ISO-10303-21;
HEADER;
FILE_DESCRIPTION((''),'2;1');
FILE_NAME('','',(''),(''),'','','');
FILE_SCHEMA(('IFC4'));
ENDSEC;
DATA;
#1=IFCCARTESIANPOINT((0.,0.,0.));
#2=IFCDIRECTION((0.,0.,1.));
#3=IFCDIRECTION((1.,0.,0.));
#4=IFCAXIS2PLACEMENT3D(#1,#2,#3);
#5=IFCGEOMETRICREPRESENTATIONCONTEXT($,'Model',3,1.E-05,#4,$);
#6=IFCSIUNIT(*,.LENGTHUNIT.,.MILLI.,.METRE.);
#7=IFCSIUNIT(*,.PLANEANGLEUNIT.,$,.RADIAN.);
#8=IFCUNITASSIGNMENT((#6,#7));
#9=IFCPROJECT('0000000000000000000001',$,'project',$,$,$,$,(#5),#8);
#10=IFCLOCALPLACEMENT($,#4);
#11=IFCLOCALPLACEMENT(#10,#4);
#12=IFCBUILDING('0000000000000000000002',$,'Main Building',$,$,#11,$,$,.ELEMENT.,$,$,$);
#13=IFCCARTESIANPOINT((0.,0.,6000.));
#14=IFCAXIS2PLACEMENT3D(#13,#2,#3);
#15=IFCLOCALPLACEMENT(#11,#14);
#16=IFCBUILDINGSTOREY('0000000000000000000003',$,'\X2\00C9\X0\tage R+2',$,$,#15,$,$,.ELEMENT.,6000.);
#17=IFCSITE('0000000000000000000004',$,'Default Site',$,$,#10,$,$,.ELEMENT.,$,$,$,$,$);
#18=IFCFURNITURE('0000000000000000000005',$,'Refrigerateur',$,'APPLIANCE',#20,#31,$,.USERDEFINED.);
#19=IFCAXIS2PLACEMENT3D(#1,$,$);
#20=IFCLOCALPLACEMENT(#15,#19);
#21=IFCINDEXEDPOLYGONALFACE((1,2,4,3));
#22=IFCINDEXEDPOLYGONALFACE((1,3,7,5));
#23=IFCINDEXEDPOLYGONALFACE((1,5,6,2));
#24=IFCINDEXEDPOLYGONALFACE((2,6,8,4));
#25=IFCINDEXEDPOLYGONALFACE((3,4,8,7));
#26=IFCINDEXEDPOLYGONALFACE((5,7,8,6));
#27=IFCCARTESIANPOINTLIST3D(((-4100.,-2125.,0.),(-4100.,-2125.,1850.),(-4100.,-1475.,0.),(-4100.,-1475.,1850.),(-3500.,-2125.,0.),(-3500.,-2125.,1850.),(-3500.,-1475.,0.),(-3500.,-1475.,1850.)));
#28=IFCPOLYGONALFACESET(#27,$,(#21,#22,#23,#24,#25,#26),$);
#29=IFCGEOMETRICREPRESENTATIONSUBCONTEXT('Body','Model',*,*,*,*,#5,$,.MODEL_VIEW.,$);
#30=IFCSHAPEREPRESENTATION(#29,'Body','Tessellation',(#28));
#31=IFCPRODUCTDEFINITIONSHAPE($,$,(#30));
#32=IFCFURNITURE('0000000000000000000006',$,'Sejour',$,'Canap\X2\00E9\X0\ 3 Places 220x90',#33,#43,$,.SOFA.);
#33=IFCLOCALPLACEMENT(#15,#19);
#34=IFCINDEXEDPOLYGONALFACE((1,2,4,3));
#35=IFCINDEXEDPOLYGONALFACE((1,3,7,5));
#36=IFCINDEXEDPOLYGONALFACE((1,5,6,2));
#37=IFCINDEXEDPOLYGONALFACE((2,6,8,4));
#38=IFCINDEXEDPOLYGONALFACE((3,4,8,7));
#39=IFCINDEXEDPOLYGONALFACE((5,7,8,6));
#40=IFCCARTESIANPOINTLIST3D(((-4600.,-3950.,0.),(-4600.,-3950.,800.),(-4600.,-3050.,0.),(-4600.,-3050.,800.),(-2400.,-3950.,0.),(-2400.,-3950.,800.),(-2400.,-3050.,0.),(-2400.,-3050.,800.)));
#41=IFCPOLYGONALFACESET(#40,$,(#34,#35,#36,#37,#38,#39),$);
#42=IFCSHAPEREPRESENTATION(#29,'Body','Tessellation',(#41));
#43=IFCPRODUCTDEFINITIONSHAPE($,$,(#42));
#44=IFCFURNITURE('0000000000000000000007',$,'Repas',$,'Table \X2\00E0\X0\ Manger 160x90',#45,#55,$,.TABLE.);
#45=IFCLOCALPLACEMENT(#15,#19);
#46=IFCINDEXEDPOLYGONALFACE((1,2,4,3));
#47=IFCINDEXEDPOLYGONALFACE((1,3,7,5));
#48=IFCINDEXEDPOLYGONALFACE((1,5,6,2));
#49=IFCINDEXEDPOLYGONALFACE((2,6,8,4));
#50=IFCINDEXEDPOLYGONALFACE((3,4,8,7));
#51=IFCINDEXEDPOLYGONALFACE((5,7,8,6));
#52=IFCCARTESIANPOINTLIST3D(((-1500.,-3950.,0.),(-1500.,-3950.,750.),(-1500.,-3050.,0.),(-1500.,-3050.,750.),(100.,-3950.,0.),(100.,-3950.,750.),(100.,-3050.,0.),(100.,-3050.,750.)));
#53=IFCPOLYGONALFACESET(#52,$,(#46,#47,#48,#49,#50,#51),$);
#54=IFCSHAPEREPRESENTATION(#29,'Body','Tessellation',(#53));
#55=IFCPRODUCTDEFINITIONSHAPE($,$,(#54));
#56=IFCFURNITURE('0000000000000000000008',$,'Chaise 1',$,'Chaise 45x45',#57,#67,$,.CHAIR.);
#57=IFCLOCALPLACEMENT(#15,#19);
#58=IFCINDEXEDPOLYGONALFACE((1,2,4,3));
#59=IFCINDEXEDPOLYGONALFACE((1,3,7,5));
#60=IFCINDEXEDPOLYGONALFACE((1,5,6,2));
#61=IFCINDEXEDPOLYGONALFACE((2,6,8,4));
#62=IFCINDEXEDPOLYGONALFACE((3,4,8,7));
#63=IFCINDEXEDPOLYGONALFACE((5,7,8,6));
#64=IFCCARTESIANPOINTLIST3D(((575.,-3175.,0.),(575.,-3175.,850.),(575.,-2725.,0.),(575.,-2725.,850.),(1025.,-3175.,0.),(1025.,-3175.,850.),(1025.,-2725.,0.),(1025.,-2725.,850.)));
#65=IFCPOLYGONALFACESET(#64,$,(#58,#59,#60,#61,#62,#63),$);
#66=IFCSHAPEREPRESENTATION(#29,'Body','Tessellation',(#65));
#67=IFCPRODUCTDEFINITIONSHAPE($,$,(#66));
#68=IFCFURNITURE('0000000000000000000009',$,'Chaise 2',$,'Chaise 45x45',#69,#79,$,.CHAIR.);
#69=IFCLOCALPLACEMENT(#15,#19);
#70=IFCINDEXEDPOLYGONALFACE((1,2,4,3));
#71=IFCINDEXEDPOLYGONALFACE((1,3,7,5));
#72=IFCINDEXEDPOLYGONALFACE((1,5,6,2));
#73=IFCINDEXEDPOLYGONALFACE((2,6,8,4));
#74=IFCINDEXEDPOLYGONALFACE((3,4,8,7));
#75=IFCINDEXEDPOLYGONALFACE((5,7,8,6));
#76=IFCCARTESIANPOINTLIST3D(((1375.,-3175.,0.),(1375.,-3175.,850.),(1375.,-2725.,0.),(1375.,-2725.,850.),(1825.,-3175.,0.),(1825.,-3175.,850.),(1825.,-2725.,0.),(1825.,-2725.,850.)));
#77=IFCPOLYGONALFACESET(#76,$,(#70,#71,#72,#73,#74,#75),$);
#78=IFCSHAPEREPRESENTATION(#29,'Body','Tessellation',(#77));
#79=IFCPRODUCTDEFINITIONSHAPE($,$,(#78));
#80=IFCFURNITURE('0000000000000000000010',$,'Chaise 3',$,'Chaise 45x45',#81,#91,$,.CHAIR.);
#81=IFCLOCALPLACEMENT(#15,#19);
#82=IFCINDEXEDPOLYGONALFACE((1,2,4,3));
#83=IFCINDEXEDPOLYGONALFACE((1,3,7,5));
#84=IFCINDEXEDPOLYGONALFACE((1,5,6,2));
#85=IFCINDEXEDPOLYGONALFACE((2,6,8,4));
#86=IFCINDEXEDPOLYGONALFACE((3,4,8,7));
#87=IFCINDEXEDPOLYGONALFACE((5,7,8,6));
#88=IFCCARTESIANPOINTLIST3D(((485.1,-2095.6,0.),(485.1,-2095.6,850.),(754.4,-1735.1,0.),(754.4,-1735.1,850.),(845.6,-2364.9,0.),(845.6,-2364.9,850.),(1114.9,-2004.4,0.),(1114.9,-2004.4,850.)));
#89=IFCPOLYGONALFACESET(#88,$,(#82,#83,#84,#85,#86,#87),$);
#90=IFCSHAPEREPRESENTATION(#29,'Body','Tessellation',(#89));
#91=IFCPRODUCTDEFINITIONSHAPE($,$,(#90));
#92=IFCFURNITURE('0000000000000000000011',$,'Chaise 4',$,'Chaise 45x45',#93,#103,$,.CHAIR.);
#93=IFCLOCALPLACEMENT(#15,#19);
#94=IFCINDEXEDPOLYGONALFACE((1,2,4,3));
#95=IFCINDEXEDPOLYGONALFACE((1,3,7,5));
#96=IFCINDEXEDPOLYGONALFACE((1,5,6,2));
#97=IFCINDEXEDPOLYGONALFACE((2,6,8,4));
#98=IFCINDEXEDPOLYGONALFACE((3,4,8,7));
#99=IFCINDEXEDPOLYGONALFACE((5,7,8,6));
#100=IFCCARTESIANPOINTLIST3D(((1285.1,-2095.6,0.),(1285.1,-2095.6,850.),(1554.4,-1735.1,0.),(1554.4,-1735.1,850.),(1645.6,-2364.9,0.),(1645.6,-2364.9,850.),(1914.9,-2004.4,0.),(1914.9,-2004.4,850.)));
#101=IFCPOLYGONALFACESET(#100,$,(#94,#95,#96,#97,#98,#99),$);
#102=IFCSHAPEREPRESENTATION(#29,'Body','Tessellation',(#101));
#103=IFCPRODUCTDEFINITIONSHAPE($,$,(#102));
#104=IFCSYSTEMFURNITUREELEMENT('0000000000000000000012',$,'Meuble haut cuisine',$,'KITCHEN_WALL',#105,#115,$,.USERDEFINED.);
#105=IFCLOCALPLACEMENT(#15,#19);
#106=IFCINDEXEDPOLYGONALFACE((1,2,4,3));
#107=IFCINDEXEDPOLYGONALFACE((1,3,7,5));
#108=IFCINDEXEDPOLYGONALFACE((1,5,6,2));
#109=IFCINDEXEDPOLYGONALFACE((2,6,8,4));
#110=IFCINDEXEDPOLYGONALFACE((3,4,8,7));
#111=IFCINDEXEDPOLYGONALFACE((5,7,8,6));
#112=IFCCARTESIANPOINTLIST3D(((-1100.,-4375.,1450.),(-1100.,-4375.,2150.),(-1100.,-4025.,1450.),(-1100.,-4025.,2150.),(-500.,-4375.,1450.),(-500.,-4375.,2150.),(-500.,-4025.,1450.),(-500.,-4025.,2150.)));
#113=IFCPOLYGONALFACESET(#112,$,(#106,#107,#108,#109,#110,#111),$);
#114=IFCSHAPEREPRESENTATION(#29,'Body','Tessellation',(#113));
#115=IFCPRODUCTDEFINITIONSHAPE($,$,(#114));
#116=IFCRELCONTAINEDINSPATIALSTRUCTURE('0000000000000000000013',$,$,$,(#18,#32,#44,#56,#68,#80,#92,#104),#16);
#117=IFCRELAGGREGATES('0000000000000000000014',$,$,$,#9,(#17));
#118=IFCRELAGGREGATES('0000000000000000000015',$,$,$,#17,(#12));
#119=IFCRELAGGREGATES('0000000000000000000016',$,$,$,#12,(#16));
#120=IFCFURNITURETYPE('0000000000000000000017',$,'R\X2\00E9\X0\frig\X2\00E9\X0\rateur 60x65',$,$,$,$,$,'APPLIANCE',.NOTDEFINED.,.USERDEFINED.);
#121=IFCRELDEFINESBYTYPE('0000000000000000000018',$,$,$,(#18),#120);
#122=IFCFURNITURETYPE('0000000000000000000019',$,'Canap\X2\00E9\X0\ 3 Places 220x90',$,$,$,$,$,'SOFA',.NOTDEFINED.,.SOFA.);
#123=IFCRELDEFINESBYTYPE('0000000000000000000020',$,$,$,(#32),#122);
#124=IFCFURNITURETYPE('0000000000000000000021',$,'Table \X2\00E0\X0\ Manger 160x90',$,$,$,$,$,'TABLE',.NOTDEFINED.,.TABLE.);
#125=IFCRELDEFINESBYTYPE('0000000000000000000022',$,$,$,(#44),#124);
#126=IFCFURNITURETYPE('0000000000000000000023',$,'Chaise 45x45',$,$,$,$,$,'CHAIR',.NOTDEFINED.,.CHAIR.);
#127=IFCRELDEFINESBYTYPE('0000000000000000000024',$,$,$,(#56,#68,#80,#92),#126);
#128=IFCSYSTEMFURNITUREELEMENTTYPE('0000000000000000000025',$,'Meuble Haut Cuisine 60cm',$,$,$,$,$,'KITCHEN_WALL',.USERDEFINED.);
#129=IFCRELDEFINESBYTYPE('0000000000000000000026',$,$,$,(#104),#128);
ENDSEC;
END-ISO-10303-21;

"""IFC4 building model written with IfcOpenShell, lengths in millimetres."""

from ifc_helpers import new_model, si_unit, frame, origin_with_axes, place, context, subcontext, project, spatial, polyline, outline, extrude, type_object, element, save


model = new_model("IFC4")

# Units and contexts
model_context = context("Model", 3, precision=1e-05, world=origin_with_axes())
body_context = subcontext(model_context, "Body", "Model", "MODEL_VIEW")
ifc_project = project(units=[si_unit("LENGTHUNIT", "METRE", prefix="MILLI"), si_unit("PLANEANGLEUNIT", "RADIAN")], contexts=[model_context])

# Site, building, storey
site_placement = place(None, origin_with_axes())
site = spatial("IfcSite", under=ifc_project, at=site_placement, Name="Default Site", CompositionType="ELEMENT")
building_placement = place(site_placement, origin_with_axes())
building = spatial("IfcBuilding", under=site, at=building_placement, Name="Main Building", CompositionType="ELEMENT")
storey_placement = place(building_placement, frame((0.0, 0.0, 6000.0), z_axis=(0.0, 0.0, 1.0), x_axis=(1.0, 0.0, 0.0)))
storey = spatial("IfcBuildingStorey", under=building, at=storey_placement, Name="Étage R+2", CompositionType="ELEMENT", Elevation=6000.0)

# Furniture
furniture_type_1 = type_object("IfcFurnitureType", Name="Réfrigérateur 60x65", ElementType="APPLIANCE", AssemblyPlace="NOTDEFINED", PredefinedType="USERDEFINED")
furniture_1_placement = place(storey_placement, frame((-3800.0, -1800.0, 0.0), z_axis=(0.0, 0.0, 1.0), x_axis=(1.0, 0.0, 0.0)))
element("IfcFurniture", 1, at=furniture_1_placement, inside=storey, type_object=furniture_type_1, Name="Refrigerateur", ObjectType="APPLIANCE", PredefinedType="USERDEFINED", context=body_context, shape_type="SweptSolid", body=[
    extrude(outline(polyline([(-300.0, -325.0), (300.0, -325.0), (300.0, 325.0), (-300.0, 325.0), (-300.0, -325.0)])), origin_with_axes(), (0.0, 0.0, 1.0), 1850.0),
])
furniture_type_2 = type_object("IfcFurnitureType", Name="Canapé 3 Places 220x90", ElementType="SOFA", AssemblyPlace="NOTDEFINED", PredefinedType="SOFA")
furniture_2_placement = place(storey_placement, frame((-3500.0, -3500.0, 0.0), z_axis=(0.0, 0.0, 1.0), x_axis=(1.0, 0.0, 0.0)))
element("IfcFurniture", 2, at=furniture_2_placement, inside=storey, type_object=furniture_type_2, Name="Sejour", ObjectType="Canapé 3 Places 220x90", PredefinedType="SOFA", context=body_context, shape_type="SweptSolid", body=[
    extrude(outline(polyline([(-1100.0, -450.0), (1100.0, -450.0), (1100.0, 450.0), (-1100.0, 450.0), (-1100.0, -450.0)])), origin_with_axes(), (0.0, 0.0, 1.0), 800.0),
])
furniture_type_3 = type_object("IfcFurnitureType", Name="Table à Manger 160x90", ElementType="TABLE", AssemblyPlace="NOTDEFINED", PredefinedType="TABLE")
furniture_3_placement = place(storey_placement, frame((-700.0, -3500.0, 0.0), z_axis=(0.0, 0.0, 1.0), x_axis=(1.0, 0.0, 0.0)))
element("IfcFurniture", 3, at=furniture_3_placement, inside=storey, type_object=furniture_type_3, Name="Repas", ObjectType="Table à Manger 160x90", PredefinedType="TABLE", context=body_context, shape_type="SweptSolid", body=[
    extrude(outline(polyline([(-800.0, -450.0), (800.0, -450.0), (800.0, 450.0), (-800.0, 450.0), (-800.0, -450.0)])), origin_with_axes(), (0.0, 0.0, 1.0), 750.0),
])
furniture_type_4 = type_object("IfcFurnitureType", Name="Chaise 45x45", ElementType="CHAIR", AssemblyPlace="NOTDEFINED", PredefinedType="CHAIR")
for number, where, z_axis, x_axis, name in (
    (4, (800.0, -2950.0, 0.0), (0.0, 0.0, 1.0), (1.0, 0.0, 0.0), "Chaise 1"),
    (5, (1600.0, -2950.0, 0.0), (0.0, 0.0, 1.0), (1.0, 0.0, 0.0), "Chaise 2"),
    (6, (800.0, -2050.0, 0.0), (0.0, 0.0, 1.0), (-0.59846, -0.801153, 0.0), "Chaise 3"),
    (7, (1600.0, -2050.0, 0.0), (0.0, 0.0, 1.0), (-0.59846, -0.801153, 0.0), "Chaise 4"),
):
    element("IfcFurniture", number, at=place(storey_placement, frame(where, z_axis=z_axis, x_axis=x_axis)), inside=storey, type_object=furniture_type_4, Name=name, ObjectType="Chaise 45x45", PredefinedType="CHAIR", context=body_context, shape_type="SweptSolid", body=[
        extrude(outline(polyline([(-225.0, -225.0), (225.0, -225.0), (225.0, 225.0), (-225.0, 225.0), (-225.0, -225.0)])), origin_with_axes(), (0.0, 0.0, 1.0), 850.0),
    ])

# System furniture element
system_furniture_element_type = type_object("IfcSystemFurnitureElementType", Name="Meuble Haut Cuisine 60cm", ElementType="KITCHEN_WALL", PredefinedType="USERDEFINED")
system_furniture_element_placement = place(storey_placement, frame((-800.0, -4200.0, 1450.0), z_axis=(0.0, 0.0, 1.0), x_axis=(1.0, 0.0, 0.0)))
element("IfcSystemFurnitureElement", 8, at=system_furniture_element_placement, inside=storey, type_object=system_furniture_element_type, Name="Meuble haut cuisine", ObjectType="KITCHEN_WALL", PredefinedType="USERDEFINED", context=body_context, shape_type="SweptSolid", body=[
    extrude(outline(polyline([(-300.0, -175.0), (300.0, -175.0), (300.0, 175.0), (-300.0, 175.0), (-300.0, -175.0)])), origin_with_axes(), (0.0, 0.0, 1.0), 700.0),
])

save(model, "model.ifc")
